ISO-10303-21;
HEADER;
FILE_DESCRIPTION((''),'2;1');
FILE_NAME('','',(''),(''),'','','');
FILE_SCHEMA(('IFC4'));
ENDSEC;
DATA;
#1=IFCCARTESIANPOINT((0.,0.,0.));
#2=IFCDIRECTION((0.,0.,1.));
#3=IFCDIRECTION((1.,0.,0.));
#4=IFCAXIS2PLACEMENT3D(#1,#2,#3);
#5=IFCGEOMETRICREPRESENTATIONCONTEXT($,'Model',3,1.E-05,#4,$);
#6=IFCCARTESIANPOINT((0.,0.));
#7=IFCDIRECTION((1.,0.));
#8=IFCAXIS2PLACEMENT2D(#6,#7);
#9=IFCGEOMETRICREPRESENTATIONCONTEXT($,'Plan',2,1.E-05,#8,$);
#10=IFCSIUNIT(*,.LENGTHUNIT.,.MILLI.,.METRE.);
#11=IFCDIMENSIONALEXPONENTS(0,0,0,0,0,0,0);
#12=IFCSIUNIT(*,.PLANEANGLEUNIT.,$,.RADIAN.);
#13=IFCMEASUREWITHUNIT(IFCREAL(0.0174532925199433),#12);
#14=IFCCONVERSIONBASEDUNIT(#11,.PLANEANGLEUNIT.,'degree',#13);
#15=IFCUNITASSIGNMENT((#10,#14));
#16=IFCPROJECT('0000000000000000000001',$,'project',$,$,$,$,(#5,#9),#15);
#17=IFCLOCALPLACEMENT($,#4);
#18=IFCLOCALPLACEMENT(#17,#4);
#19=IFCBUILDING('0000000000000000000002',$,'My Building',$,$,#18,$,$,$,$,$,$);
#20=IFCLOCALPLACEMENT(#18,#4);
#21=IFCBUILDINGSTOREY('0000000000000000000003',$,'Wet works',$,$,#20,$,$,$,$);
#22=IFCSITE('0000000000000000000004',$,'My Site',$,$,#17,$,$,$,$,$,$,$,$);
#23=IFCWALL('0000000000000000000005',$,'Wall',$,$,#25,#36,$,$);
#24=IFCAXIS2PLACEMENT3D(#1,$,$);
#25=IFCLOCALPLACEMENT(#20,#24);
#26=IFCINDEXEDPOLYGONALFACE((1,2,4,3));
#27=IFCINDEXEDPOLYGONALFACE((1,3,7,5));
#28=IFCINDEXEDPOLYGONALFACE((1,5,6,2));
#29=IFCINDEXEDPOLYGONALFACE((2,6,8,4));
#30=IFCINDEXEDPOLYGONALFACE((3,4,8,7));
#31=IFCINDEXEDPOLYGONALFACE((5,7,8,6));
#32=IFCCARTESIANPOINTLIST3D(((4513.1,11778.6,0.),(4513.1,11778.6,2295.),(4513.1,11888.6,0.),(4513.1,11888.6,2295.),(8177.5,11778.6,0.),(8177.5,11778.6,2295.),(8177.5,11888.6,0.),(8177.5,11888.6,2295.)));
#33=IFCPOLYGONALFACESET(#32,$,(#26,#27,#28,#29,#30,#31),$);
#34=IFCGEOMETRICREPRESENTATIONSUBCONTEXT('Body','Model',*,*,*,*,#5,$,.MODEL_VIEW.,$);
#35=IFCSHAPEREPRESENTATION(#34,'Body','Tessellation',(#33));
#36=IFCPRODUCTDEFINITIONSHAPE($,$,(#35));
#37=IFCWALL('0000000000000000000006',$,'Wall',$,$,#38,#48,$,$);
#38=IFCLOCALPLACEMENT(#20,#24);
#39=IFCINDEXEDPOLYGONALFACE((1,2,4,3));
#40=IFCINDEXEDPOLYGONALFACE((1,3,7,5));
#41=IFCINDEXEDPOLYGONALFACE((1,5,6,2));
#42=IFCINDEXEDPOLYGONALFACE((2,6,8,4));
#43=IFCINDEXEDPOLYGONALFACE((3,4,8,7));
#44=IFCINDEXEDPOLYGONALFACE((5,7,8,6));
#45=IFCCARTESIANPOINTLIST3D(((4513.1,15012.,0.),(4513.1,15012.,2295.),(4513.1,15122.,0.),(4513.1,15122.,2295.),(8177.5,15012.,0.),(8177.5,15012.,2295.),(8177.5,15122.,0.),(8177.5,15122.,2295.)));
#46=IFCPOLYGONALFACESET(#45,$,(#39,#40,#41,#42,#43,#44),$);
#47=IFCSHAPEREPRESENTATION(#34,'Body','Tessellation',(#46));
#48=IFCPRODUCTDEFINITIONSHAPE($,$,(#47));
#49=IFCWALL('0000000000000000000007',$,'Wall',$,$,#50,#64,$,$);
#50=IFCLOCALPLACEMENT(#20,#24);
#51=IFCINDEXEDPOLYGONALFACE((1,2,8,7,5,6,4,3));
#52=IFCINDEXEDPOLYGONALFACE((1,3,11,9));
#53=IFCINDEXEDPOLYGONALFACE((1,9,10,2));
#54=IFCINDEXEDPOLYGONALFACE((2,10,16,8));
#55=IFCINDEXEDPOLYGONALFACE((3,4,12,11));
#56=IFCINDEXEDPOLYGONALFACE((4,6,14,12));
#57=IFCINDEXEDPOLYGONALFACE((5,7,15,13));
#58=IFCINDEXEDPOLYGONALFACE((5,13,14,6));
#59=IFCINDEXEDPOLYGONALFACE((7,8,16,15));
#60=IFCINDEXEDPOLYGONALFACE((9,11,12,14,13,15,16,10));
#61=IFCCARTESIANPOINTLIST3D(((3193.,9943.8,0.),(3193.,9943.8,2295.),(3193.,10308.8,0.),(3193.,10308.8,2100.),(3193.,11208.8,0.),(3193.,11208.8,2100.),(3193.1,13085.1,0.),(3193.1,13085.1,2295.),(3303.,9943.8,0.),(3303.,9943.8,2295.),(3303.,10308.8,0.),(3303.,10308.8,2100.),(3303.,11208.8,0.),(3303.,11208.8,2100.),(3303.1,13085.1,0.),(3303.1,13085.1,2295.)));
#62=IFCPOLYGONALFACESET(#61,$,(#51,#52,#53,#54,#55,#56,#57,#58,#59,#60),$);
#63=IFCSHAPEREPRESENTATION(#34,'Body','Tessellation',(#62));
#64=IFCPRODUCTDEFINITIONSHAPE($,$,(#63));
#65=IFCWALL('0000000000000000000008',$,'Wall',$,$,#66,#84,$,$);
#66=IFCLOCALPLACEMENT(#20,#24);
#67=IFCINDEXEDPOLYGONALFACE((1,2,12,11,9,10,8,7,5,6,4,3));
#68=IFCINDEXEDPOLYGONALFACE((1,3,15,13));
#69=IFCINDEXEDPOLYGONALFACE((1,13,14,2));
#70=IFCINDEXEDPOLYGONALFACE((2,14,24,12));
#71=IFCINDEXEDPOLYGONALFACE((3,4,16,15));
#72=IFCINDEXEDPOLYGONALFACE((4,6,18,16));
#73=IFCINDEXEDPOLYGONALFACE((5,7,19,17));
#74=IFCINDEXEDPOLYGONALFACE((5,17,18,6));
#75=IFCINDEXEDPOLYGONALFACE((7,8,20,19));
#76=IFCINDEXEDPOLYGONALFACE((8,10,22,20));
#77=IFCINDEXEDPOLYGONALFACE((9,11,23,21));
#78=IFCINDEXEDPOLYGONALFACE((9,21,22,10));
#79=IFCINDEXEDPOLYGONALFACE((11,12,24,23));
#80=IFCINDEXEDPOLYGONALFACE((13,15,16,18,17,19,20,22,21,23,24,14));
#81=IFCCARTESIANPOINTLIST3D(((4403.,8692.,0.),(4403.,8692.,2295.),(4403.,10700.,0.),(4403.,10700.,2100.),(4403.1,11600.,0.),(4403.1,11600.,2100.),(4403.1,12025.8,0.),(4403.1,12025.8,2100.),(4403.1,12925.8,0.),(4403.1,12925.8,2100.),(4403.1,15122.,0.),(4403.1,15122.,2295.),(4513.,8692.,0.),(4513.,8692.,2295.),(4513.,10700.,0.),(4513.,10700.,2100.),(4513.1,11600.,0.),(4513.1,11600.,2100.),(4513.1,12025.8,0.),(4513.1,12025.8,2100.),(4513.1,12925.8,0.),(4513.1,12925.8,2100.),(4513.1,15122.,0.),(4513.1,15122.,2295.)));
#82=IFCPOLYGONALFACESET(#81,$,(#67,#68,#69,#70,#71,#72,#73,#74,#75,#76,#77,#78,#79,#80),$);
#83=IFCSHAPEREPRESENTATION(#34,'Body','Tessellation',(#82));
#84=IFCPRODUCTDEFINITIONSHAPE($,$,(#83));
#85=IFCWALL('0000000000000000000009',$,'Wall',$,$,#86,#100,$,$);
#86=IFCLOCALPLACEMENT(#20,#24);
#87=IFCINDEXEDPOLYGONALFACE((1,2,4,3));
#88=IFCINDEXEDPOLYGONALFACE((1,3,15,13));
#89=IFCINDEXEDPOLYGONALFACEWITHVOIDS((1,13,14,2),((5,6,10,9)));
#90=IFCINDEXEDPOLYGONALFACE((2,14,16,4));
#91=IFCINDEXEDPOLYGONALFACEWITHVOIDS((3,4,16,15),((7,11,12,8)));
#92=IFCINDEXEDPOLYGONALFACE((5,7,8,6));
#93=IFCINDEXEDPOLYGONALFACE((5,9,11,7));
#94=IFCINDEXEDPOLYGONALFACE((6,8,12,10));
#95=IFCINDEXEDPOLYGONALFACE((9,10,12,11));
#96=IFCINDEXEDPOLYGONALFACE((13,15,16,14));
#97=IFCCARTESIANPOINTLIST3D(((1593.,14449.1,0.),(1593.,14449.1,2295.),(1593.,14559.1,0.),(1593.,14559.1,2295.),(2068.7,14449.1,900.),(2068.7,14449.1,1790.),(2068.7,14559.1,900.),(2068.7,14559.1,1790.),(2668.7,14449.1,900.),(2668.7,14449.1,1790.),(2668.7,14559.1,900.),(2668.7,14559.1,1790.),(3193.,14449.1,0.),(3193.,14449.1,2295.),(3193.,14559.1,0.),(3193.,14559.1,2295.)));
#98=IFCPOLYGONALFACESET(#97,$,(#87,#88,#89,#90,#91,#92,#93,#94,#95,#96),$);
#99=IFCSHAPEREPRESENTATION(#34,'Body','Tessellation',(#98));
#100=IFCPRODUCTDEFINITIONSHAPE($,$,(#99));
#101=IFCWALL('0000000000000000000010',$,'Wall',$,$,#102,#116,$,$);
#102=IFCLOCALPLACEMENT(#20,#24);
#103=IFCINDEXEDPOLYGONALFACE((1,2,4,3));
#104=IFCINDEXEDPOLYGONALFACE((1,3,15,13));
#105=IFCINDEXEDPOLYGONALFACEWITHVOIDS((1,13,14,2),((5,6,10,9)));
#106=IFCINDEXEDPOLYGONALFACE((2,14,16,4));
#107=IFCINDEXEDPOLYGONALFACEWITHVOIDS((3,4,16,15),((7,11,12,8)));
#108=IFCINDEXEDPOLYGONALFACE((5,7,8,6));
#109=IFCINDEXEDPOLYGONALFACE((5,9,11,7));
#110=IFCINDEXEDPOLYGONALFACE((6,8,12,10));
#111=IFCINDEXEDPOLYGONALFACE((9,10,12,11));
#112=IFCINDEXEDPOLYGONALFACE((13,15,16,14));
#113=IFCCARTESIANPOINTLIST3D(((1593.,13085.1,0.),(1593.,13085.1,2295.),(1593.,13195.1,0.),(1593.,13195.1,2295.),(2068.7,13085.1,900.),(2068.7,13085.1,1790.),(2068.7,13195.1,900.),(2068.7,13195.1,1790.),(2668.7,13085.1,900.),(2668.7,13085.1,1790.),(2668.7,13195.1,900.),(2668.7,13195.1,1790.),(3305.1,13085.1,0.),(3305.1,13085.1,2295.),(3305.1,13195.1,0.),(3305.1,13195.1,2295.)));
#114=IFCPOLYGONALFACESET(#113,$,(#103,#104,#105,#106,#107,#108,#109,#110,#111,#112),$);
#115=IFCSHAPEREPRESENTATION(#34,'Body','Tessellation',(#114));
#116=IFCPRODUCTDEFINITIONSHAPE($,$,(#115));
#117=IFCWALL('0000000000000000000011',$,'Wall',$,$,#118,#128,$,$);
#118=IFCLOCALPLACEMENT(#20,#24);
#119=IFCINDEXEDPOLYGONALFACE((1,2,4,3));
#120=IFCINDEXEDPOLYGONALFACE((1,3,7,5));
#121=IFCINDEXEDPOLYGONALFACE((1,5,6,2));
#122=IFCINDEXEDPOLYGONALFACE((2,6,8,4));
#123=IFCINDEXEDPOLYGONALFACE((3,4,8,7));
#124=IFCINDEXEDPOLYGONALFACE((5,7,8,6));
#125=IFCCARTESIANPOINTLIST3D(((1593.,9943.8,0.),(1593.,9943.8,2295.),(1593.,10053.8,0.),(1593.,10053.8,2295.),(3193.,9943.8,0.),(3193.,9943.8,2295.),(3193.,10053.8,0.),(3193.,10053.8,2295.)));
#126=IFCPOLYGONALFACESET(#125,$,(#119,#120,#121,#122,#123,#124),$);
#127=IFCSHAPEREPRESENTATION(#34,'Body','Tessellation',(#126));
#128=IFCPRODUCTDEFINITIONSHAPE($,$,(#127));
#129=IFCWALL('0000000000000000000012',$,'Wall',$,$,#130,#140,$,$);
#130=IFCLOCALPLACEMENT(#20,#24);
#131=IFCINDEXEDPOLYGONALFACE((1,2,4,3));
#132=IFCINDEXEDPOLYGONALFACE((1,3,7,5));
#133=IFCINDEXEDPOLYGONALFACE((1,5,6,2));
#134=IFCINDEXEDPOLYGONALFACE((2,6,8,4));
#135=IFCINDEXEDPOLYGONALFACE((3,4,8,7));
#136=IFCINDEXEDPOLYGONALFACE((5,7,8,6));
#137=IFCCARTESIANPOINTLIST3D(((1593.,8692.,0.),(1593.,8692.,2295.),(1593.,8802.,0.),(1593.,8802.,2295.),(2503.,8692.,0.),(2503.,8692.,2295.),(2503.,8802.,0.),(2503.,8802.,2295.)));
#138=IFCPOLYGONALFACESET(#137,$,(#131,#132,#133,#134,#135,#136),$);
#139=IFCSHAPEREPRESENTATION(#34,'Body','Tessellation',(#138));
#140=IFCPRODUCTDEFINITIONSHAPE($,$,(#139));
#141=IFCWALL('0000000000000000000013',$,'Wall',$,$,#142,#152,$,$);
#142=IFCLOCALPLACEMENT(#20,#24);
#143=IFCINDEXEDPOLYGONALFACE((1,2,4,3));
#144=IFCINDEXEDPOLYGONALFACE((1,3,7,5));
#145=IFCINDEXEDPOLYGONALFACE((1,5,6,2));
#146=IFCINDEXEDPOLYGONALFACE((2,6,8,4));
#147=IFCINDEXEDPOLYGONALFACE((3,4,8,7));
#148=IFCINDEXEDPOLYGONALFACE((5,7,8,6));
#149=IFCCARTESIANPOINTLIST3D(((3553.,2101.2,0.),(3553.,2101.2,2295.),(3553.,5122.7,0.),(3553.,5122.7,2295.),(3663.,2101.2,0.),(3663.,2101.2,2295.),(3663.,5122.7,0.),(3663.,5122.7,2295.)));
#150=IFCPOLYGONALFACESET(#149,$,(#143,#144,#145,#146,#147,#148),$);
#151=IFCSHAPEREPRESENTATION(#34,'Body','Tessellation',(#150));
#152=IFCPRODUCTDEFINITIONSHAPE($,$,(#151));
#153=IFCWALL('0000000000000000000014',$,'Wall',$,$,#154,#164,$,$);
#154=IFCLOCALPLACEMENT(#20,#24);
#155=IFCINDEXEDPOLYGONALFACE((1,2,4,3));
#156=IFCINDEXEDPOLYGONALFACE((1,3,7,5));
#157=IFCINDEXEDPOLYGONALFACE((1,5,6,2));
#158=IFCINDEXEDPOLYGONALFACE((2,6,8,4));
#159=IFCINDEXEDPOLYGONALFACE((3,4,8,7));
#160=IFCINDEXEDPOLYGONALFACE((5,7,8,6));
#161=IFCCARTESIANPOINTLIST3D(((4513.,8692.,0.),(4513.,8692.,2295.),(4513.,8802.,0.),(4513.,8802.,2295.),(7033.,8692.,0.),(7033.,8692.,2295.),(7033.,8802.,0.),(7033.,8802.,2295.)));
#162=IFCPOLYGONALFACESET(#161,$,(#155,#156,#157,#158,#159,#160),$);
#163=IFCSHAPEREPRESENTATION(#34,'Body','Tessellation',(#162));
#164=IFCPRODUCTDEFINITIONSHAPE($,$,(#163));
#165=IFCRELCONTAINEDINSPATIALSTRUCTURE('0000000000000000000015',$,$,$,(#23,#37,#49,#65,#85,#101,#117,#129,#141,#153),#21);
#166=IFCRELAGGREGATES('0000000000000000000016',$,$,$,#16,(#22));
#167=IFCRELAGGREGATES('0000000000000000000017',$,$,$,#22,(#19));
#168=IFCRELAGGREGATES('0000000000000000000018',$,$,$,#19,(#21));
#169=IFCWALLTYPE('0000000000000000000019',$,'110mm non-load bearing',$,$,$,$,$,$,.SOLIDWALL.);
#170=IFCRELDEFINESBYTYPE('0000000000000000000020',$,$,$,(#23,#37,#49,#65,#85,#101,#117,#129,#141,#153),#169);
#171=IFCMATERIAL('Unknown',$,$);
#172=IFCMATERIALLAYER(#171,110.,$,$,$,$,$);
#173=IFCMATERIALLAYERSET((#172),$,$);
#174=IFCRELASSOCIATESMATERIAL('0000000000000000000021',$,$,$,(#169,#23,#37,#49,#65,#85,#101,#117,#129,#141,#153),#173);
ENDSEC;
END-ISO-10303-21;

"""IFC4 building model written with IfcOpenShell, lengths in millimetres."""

from ifc_helpers import new_model, entity, si_unit, converted_unit, frame, origin_with_axes, origin_2d_with_axis, place, context, subcontext, project, spatial, line, indexed_curve, outline, extrude, source, transform, mapped, material, layer, layer_set, layer_usage, type_object, element, save


model = new_model("IFC4")

# Units and contexts
model_context = context("Model", 3, precision=1e-05, world=origin_with_axes())
plan_context = context("Plan", 2, precision=1e-05, world=origin_2d_with_axis())
body_context_1 = subcontext(model_context, "Body", "Model", "MODEL_VIEW")
ifc_project = project(units=[si_unit("LENGTHUNIT", "METRE", prefix="MILLI"), converted_unit("PLANEANGLEUNIT", "degree", entity("IfcReal", 0.0174532925199433), si_unit("PLANEANGLEUNIT", "RADIAN"), dimensions=[0, 0, 0, 0, 0, 0, 0])], contexts=[model_context, plan_context])

# Site, building, storey
site_placement = place(None, origin_with_axes())
site = spatial("IfcSite", under=ifc_project, at=site_placement, Name="My Site")
building_placement = place(site_placement, origin_with_axes())
building = spatial("IfcBuilding", under=site, at=building_placement, Name="My Building")
storey_placement = place(building_placement, origin_with_axes())
storey = spatial("IfcBuildingStorey", under=building, at=storey_placement, Name="Wet works")

# Walls
ifc_material_1 = material(Name="Unknown")
ifc_layer_1 = layer(ifc_material_1, 110.0)
ifc_layer_set_1 = layer_set([ifc_layer_1])
ifc_layer_usage_1 = layer_usage(ifc_layer_set_1, "AXIS2", "POSITIVE", 0.0)
wall_type_1 = type_object("IfcWallType", Name="110mm non-load bearing", PredefinedType="SOLIDWALL", material=ifc_layer_set_1)
wall_1_placement = place(storey_placement, frame((4513.1, 11778.6, 0.0), z_axis=(0.0, 0.0, 1.0), x_axis=(1.0, 0.0, 0.0)))
element("IfcWall", 1, at=wall_1_placement, inside=storey, type_object=wall_type_1, material=ifc_layer_usage_1, Name="Wall", context=body_context_1, shape_type="SweptSolid", body=[
    extrude(outline(indexed_curve([(0.0, 0.0), (0.0, 110.0), (3664.5, 110.0), (3664.5, 0.0), (0.0, 0.0)], self_intersect=False)), origin_with_axes(), (0.0, 0.0, 1.0), 2295.0),
])
ifc_layer_usage_2 = layer_usage(ifc_layer_set_1, "AXIS2", "POSITIVE", 0.0)
wall_2_placement = place(storey_placement, frame((4513.1, 15012.0, 0.0), z_axis=(0.0, 0.0, 1.0), x_axis=(1.0, 0.0, 0.0)))
element("IfcWall", 2, at=wall_2_placement, inside=storey, type_object=wall_type_1, material=ifc_layer_usage_2, Name="Wall", context=body_context_1, shape_type="SweptSolid", body=[
    extrude(outline(indexed_curve([(0.0, 0.0), (0.0, 110.0), (3664.5, 110.0), (3664.5, 0.0), (0.0, 0.0)], self_intersect=False)), origin_with_axes(), (0.0, 0.0, 1.0), 2295.0),
])

# Wall, opening
ifc_layer_usage_3 = layer_usage(ifc_layer_set_1, "AXIS2", "POSITIVE", 0.0)
wall_3_placement = place(storey_placement, frame((3303.0, 9943.8, 0.0), z_axis=(0.0, 0.0, 1.0), x_axis=(0.0, 1.0, 0.0)))
wall_3 = element("IfcWall", 3, at=wall_3_placement, inside=storey, type_object=wall_type_1, material=ifc_layer_usage_3, Name="Wall", context=body_context_1, shape_type="SweptSolid", body=[
    extrude(outline(indexed_curve([(0.0, 0.0), (0.0, 110.0), (3141.4, 110.0), (3141.4, 0.0), (0.0, 0.0)], self_intersect=False)), origin_with_axes(), (0.0, 0.0, 1.0), 2295.0),
])
shared_shape_1 = source(origin_with_axes(), body_context_1, "Body", "SweptSolid", [
    extrude(outline(indexed_curve([(0.0, 0.0), (900.0, 0.0), (900.0, 2100.0), (0.0, 2100.0)], segments=[line(1, 2, 3, 4, 1)])), frame((0.0, -600.0, 0.0), z_axis=(0.0, -1.0, 0.0), x_axis=(1.0, 0.0, 0.0)), (0.0, 0.0, -1.0), 1200.0),
])
opening_1_placement = place(wall_3_placement, frame((365.0, 20.0, 0.0), z_axis=(0.0, 0.0, 1.0), x_axis=(1.0, 0.0, 0.0)))
element("IfcOpeningElement", 4, at=opening_1_placement, cuts=wall_3, PredefinedType="OPENING", context=body_context_1, shape_type="MappedRepresentation", body=[
    mapped(shared_shape_1, transform((0.0, 0.0, 0.0), x_axis=(1.0, 0.0, 0.0), y_axis=(0.0, 1.0, 0.0), z_axis=(0.0, 0.0, 1.0), scale=1.0)),
])

# Wall, openings
ifc_layer_usage_4 = layer_usage(ifc_layer_set_1, "AXIS2", "POSITIVE", 0.0)
wall_4_placement = place(storey_placement, frame((4513.0, 8692.0, 0.0), z_axis=(0.0, 0.0, 1.0), x_axis=(0.0, 1.0, 0.0)))
wall_4 = element("IfcWall", 5, at=wall_4_placement, inside=storey, type_object=wall_type_1, material=ifc_layer_usage_4, Name="Wall", context=body_context_1, shape_type="SweptSolid", body=[
    extrude(outline(indexed_curve([(0.0, 0.0), (0.0, 110.0), (6430.0, 110.0), (6430.0, 0.0), (0.0, 0.0)], self_intersect=False)), origin_with_axes(), (0.0, 0.0, 1.0), 2295.0),
])
shared_shape_2 = source(origin_with_axes(), body_context_1, "Body", "SweptSolid", [
    extrude(outline(indexed_curve([(0.0, 0.0), (900.0, 0.0), (900.0, 2100.0), (0.0, 2100.0)], segments=[line(1, 2, 3, 4, 1)])), frame((0.0, -600.0, 0.0), z_axis=(0.0, -1.0, 0.0), x_axis=(1.0, 0.0, 0.0)), (0.0, 0.0, -1.0), 1200.0),
])
opening_2_placement = place(wall_4_placement, frame((2008.1, -80.0, 0.0), z_axis=(0.0, 0.0, 1.0), x_axis=(1.0, 0.0, 0.0)))
element("IfcOpeningElement", 6, at=opening_2_placement, cuts=wall_4, PredefinedType="OPENING", context=body_context_1, shape_type="MappedRepresentation", body=[
    mapped(shared_shape_2, transform((0.0, 0.0, 0.0), x_axis=(1.0, 0.0, 0.0), y_axis=(0.0, 1.0, 0.0), z_axis=(0.0, 0.0, 1.0), scale=1.0)),
])
opening_3_placement = place(wall_4_placement, frame((3333.9, -80.0, 0.0), z_axis=(0.0, 0.0, 1.0), x_axis=(1.0, 0.0, 0.0)))
element("IfcOpeningElement", 7, at=opening_3_placement, cuts=wall_4, PredefinedType="OPENING", context=body_context_1, shape_type="MappedRepresentation", body=[
    mapped(shared_shape_2, transform((0.0, 0.0, 0.0), x_axis=(1.0, 0.0, 0.0), y_axis=(0.0, 1.0, 0.0), z_axis=(0.0, 0.0, 1.0), scale=1.0)),
])

# Walls, openings
ifc_layer_usage_5 = layer_usage(ifc_layer_set_1, "AXIS2", "POSITIVE", 0.0)
wall_5_placement = place(storey_placement, frame((1593.0, 14449.1, 0.0), z_axis=(0.0, 0.0, 1.0), x_axis=(1.0, 0.0, 0.0)))
wall_5 = element("IfcWall", 8, at=wall_5_placement, inside=storey, type_object=wall_type_1, material=ifc_layer_usage_5, Name="Wall", context=body_context_1, shape_type="SweptSolid", body=[
    extrude(outline(indexed_curve([(0.0, 0.0), (0.0, 110.0), (1600.0, 110.0), (1600.0, 0.0), (0.0, 0.0)], self_intersect=False)), origin_with_axes(), (0.0, 0.0, 1.0), 2295.0),
])
shared_shape_3 = source(origin_with_axes(), body_context_1, "Body", "SweptSolid", [
    extrude(outline(indexed_curve([(0.0, 0.0), (600.0, 0.0), (600.0, 890.0), (0.0, 890.0)], segments=[line(1, 2, 3, 4, 1)])), frame((0.0, -600.0, 0.0), z_axis=(0.0, -1.0, 0.0), x_axis=(1.0, 0.0, 0.0)), (0.0, 0.0, -1.0), 1200.0),
])
opening_4_placement = place(wall_5_placement, frame((475.7, 0.0, 900.0), z_axis=(0.0, 0.0, 1.0), x_axis=(1.0, 0.0, 0.0)))
element("IfcOpeningElement", 9, at=opening_4_placement, cuts=wall_5, PredefinedType="OPENING", context=body_context_1, shape_type="MappedRepresentation", body=[
    mapped(shared_shape_3, transform((0.0, 0.0, 0.0), x_axis=(1.0, 0.0, 0.0), y_axis=(0.0, 1.0, 0.0), z_axis=(0.0, 0.0, 1.0), scale=1.0)),
])
ifc_layer_usage_6 = layer_usage(ifc_layer_set_1, "AXIS2", "POSITIVE", 0.0)
wall_6_placement = place(storey_placement, frame((1593.0, 13085.1, 0.0), z_axis=(0.0, 0.0, 1.0), x_axis=(1.0, 0.0, 0.0)))
wall_6 = element("IfcWall", 10, at=wall_6_placement, inside=storey, type_object=wall_type_1, material=ifc_layer_usage_6, Name="Wall", context=body_context_1, shape_type="SweptSolid", body=[
    extrude(outline(indexed_curve([(0.0, 0.0), (0.0, 110.0), (1712.0, 110.0), (1712.0, 0.0), (0.0, 0.0)], self_intersect=False)), origin_with_axes(), (0.0, 0.0, 1.0), 2295.0),
])
opening_5_placement = place(wall_6_placement, frame((475.7, 0.0, 900.0), z_axis=(0.0, 0.0, 1.0), x_axis=(1.0, 0.0, 0.0)))
element("IfcOpeningElement", 11, at=opening_5_placement, cuts=wall_6, PredefinedType="OPENING", context=body_context_1, shape_type="MappedRepresentation", body=[
    mapped(shared_shape_3, transform((0.0, 0.0, 0.0), x_axis=(1.0, 0.0, 0.0), y_axis=(0.0, 1.0, 0.0), z_axis=(0.0, 0.0, 1.0), scale=1.0)),
])

# Walls
ifc_layer_usage_7 = layer_usage(ifc_layer_set_1, "AXIS2", "POSITIVE", 0.0)
wall_7_placement = place(storey_placement, frame((1593.0, 9943.8, 0.0), z_axis=(0.0, 0.0, 1.0), x_axis=(1.0, 0.0, 0.0)))
element("IfcWall", 12, at=wall_7_placement, inside=storey, type_object=wall_type_1, material=ifc_layer_usage_7, Name="Wall", context=body_context_1, shape_type="SweptSolid", body=[
    extrude(outline(indexed_curve([(0.0, 0.0), (0.0, 110.0), (1600.0, 110.0), (1600.0, 0.0), (0.0, 0.0)], self_intersect=False)), origin_with_axes(), (0.0, 0.0, 1.0), 2295.0),
])
ifc_layer_usage_8 = layer_usage(ifc_layer_set_1, "AXIS2", "POSITIVE", 0.0)
wall_8_placement = place(storey_placement, frame((1593.0, 8692.0, 0.0), z_axis=(0.0, 0.0, 1.0), x_axis=(1.0, 0.0, 0.0)))
element("IfcWall", 13, at=wall_8_placement, inside=storey, type_object=wall_type_1, material=ifc_layer_usage_8, Name="Wall", context=body_context_1, shape_type="SweptSolid", body=[
    extrude(outline(indexed_curve([(0.0, 0.0), (0.0, 110.0), (910.0, 110.0), (910.0, 0.0), (0.0, 0.0)], self_intersect=False)), origin_with_axes(), (0.0, 0.0, 1.0), 2295.0),
])
ifc_layer_usage_9 = layer_usage(ifc_layer_set_1, "AXIS2", "POSITIVE", 0.0)
wall_9_placement = place(storey_placement, frame((3663.0, 2101.2, 0.0), z_axis=(0.0, 0.0, 1.0), x_axis=(0.0, 1.0, 0.0)))
element("IfcWall", 14, at=wall_9_placement, inside=storey, type_object=wall_type_1, material=ifc_layer_usage_9, Name="Wall", context=body_context_1, shape_type="SweptSolid", body=[
    extrude(outline(indexed_curve([(0.0, 0.0), (0.0, 110.0), (3021.6, 110.0), (3021.6, 0.0), (0.0, 0.0)], self_intersect=False)), origin_with_axes(), (0.0, 0.0, 1.0), 2295.0),
])
ifc_layer_usage_10 = layer_usage(ifc_layer_set_1, "AXIS2", "POSITIVE", 0.0)
wall_10_placement = place(storey_placement, frame((4513.0, 8692.0, 0.0), z_axis=(0.0, 0.0, 1.0), x_axis=(1.0, 0.0, 0.0)))
element("IfcWall", 15, at=wall_10_placement, inside=storey, type_object=wall_type_1, material=ifc_layer_usage_10, Name="Wall", context=body_context_1, shape_type="SweptSolid", body=[
    extrude(outline(indexed_curve([(0.0, 0.0), (0.0, 110.0), (2520.0, 110.0), (2520.0, 0.0), (0.0, 0.0)], self_intersect=False)), origin_with_axes(), (0.0, 0.0, 1.0), 2295.0),
])

save(model, "model.ifc")
